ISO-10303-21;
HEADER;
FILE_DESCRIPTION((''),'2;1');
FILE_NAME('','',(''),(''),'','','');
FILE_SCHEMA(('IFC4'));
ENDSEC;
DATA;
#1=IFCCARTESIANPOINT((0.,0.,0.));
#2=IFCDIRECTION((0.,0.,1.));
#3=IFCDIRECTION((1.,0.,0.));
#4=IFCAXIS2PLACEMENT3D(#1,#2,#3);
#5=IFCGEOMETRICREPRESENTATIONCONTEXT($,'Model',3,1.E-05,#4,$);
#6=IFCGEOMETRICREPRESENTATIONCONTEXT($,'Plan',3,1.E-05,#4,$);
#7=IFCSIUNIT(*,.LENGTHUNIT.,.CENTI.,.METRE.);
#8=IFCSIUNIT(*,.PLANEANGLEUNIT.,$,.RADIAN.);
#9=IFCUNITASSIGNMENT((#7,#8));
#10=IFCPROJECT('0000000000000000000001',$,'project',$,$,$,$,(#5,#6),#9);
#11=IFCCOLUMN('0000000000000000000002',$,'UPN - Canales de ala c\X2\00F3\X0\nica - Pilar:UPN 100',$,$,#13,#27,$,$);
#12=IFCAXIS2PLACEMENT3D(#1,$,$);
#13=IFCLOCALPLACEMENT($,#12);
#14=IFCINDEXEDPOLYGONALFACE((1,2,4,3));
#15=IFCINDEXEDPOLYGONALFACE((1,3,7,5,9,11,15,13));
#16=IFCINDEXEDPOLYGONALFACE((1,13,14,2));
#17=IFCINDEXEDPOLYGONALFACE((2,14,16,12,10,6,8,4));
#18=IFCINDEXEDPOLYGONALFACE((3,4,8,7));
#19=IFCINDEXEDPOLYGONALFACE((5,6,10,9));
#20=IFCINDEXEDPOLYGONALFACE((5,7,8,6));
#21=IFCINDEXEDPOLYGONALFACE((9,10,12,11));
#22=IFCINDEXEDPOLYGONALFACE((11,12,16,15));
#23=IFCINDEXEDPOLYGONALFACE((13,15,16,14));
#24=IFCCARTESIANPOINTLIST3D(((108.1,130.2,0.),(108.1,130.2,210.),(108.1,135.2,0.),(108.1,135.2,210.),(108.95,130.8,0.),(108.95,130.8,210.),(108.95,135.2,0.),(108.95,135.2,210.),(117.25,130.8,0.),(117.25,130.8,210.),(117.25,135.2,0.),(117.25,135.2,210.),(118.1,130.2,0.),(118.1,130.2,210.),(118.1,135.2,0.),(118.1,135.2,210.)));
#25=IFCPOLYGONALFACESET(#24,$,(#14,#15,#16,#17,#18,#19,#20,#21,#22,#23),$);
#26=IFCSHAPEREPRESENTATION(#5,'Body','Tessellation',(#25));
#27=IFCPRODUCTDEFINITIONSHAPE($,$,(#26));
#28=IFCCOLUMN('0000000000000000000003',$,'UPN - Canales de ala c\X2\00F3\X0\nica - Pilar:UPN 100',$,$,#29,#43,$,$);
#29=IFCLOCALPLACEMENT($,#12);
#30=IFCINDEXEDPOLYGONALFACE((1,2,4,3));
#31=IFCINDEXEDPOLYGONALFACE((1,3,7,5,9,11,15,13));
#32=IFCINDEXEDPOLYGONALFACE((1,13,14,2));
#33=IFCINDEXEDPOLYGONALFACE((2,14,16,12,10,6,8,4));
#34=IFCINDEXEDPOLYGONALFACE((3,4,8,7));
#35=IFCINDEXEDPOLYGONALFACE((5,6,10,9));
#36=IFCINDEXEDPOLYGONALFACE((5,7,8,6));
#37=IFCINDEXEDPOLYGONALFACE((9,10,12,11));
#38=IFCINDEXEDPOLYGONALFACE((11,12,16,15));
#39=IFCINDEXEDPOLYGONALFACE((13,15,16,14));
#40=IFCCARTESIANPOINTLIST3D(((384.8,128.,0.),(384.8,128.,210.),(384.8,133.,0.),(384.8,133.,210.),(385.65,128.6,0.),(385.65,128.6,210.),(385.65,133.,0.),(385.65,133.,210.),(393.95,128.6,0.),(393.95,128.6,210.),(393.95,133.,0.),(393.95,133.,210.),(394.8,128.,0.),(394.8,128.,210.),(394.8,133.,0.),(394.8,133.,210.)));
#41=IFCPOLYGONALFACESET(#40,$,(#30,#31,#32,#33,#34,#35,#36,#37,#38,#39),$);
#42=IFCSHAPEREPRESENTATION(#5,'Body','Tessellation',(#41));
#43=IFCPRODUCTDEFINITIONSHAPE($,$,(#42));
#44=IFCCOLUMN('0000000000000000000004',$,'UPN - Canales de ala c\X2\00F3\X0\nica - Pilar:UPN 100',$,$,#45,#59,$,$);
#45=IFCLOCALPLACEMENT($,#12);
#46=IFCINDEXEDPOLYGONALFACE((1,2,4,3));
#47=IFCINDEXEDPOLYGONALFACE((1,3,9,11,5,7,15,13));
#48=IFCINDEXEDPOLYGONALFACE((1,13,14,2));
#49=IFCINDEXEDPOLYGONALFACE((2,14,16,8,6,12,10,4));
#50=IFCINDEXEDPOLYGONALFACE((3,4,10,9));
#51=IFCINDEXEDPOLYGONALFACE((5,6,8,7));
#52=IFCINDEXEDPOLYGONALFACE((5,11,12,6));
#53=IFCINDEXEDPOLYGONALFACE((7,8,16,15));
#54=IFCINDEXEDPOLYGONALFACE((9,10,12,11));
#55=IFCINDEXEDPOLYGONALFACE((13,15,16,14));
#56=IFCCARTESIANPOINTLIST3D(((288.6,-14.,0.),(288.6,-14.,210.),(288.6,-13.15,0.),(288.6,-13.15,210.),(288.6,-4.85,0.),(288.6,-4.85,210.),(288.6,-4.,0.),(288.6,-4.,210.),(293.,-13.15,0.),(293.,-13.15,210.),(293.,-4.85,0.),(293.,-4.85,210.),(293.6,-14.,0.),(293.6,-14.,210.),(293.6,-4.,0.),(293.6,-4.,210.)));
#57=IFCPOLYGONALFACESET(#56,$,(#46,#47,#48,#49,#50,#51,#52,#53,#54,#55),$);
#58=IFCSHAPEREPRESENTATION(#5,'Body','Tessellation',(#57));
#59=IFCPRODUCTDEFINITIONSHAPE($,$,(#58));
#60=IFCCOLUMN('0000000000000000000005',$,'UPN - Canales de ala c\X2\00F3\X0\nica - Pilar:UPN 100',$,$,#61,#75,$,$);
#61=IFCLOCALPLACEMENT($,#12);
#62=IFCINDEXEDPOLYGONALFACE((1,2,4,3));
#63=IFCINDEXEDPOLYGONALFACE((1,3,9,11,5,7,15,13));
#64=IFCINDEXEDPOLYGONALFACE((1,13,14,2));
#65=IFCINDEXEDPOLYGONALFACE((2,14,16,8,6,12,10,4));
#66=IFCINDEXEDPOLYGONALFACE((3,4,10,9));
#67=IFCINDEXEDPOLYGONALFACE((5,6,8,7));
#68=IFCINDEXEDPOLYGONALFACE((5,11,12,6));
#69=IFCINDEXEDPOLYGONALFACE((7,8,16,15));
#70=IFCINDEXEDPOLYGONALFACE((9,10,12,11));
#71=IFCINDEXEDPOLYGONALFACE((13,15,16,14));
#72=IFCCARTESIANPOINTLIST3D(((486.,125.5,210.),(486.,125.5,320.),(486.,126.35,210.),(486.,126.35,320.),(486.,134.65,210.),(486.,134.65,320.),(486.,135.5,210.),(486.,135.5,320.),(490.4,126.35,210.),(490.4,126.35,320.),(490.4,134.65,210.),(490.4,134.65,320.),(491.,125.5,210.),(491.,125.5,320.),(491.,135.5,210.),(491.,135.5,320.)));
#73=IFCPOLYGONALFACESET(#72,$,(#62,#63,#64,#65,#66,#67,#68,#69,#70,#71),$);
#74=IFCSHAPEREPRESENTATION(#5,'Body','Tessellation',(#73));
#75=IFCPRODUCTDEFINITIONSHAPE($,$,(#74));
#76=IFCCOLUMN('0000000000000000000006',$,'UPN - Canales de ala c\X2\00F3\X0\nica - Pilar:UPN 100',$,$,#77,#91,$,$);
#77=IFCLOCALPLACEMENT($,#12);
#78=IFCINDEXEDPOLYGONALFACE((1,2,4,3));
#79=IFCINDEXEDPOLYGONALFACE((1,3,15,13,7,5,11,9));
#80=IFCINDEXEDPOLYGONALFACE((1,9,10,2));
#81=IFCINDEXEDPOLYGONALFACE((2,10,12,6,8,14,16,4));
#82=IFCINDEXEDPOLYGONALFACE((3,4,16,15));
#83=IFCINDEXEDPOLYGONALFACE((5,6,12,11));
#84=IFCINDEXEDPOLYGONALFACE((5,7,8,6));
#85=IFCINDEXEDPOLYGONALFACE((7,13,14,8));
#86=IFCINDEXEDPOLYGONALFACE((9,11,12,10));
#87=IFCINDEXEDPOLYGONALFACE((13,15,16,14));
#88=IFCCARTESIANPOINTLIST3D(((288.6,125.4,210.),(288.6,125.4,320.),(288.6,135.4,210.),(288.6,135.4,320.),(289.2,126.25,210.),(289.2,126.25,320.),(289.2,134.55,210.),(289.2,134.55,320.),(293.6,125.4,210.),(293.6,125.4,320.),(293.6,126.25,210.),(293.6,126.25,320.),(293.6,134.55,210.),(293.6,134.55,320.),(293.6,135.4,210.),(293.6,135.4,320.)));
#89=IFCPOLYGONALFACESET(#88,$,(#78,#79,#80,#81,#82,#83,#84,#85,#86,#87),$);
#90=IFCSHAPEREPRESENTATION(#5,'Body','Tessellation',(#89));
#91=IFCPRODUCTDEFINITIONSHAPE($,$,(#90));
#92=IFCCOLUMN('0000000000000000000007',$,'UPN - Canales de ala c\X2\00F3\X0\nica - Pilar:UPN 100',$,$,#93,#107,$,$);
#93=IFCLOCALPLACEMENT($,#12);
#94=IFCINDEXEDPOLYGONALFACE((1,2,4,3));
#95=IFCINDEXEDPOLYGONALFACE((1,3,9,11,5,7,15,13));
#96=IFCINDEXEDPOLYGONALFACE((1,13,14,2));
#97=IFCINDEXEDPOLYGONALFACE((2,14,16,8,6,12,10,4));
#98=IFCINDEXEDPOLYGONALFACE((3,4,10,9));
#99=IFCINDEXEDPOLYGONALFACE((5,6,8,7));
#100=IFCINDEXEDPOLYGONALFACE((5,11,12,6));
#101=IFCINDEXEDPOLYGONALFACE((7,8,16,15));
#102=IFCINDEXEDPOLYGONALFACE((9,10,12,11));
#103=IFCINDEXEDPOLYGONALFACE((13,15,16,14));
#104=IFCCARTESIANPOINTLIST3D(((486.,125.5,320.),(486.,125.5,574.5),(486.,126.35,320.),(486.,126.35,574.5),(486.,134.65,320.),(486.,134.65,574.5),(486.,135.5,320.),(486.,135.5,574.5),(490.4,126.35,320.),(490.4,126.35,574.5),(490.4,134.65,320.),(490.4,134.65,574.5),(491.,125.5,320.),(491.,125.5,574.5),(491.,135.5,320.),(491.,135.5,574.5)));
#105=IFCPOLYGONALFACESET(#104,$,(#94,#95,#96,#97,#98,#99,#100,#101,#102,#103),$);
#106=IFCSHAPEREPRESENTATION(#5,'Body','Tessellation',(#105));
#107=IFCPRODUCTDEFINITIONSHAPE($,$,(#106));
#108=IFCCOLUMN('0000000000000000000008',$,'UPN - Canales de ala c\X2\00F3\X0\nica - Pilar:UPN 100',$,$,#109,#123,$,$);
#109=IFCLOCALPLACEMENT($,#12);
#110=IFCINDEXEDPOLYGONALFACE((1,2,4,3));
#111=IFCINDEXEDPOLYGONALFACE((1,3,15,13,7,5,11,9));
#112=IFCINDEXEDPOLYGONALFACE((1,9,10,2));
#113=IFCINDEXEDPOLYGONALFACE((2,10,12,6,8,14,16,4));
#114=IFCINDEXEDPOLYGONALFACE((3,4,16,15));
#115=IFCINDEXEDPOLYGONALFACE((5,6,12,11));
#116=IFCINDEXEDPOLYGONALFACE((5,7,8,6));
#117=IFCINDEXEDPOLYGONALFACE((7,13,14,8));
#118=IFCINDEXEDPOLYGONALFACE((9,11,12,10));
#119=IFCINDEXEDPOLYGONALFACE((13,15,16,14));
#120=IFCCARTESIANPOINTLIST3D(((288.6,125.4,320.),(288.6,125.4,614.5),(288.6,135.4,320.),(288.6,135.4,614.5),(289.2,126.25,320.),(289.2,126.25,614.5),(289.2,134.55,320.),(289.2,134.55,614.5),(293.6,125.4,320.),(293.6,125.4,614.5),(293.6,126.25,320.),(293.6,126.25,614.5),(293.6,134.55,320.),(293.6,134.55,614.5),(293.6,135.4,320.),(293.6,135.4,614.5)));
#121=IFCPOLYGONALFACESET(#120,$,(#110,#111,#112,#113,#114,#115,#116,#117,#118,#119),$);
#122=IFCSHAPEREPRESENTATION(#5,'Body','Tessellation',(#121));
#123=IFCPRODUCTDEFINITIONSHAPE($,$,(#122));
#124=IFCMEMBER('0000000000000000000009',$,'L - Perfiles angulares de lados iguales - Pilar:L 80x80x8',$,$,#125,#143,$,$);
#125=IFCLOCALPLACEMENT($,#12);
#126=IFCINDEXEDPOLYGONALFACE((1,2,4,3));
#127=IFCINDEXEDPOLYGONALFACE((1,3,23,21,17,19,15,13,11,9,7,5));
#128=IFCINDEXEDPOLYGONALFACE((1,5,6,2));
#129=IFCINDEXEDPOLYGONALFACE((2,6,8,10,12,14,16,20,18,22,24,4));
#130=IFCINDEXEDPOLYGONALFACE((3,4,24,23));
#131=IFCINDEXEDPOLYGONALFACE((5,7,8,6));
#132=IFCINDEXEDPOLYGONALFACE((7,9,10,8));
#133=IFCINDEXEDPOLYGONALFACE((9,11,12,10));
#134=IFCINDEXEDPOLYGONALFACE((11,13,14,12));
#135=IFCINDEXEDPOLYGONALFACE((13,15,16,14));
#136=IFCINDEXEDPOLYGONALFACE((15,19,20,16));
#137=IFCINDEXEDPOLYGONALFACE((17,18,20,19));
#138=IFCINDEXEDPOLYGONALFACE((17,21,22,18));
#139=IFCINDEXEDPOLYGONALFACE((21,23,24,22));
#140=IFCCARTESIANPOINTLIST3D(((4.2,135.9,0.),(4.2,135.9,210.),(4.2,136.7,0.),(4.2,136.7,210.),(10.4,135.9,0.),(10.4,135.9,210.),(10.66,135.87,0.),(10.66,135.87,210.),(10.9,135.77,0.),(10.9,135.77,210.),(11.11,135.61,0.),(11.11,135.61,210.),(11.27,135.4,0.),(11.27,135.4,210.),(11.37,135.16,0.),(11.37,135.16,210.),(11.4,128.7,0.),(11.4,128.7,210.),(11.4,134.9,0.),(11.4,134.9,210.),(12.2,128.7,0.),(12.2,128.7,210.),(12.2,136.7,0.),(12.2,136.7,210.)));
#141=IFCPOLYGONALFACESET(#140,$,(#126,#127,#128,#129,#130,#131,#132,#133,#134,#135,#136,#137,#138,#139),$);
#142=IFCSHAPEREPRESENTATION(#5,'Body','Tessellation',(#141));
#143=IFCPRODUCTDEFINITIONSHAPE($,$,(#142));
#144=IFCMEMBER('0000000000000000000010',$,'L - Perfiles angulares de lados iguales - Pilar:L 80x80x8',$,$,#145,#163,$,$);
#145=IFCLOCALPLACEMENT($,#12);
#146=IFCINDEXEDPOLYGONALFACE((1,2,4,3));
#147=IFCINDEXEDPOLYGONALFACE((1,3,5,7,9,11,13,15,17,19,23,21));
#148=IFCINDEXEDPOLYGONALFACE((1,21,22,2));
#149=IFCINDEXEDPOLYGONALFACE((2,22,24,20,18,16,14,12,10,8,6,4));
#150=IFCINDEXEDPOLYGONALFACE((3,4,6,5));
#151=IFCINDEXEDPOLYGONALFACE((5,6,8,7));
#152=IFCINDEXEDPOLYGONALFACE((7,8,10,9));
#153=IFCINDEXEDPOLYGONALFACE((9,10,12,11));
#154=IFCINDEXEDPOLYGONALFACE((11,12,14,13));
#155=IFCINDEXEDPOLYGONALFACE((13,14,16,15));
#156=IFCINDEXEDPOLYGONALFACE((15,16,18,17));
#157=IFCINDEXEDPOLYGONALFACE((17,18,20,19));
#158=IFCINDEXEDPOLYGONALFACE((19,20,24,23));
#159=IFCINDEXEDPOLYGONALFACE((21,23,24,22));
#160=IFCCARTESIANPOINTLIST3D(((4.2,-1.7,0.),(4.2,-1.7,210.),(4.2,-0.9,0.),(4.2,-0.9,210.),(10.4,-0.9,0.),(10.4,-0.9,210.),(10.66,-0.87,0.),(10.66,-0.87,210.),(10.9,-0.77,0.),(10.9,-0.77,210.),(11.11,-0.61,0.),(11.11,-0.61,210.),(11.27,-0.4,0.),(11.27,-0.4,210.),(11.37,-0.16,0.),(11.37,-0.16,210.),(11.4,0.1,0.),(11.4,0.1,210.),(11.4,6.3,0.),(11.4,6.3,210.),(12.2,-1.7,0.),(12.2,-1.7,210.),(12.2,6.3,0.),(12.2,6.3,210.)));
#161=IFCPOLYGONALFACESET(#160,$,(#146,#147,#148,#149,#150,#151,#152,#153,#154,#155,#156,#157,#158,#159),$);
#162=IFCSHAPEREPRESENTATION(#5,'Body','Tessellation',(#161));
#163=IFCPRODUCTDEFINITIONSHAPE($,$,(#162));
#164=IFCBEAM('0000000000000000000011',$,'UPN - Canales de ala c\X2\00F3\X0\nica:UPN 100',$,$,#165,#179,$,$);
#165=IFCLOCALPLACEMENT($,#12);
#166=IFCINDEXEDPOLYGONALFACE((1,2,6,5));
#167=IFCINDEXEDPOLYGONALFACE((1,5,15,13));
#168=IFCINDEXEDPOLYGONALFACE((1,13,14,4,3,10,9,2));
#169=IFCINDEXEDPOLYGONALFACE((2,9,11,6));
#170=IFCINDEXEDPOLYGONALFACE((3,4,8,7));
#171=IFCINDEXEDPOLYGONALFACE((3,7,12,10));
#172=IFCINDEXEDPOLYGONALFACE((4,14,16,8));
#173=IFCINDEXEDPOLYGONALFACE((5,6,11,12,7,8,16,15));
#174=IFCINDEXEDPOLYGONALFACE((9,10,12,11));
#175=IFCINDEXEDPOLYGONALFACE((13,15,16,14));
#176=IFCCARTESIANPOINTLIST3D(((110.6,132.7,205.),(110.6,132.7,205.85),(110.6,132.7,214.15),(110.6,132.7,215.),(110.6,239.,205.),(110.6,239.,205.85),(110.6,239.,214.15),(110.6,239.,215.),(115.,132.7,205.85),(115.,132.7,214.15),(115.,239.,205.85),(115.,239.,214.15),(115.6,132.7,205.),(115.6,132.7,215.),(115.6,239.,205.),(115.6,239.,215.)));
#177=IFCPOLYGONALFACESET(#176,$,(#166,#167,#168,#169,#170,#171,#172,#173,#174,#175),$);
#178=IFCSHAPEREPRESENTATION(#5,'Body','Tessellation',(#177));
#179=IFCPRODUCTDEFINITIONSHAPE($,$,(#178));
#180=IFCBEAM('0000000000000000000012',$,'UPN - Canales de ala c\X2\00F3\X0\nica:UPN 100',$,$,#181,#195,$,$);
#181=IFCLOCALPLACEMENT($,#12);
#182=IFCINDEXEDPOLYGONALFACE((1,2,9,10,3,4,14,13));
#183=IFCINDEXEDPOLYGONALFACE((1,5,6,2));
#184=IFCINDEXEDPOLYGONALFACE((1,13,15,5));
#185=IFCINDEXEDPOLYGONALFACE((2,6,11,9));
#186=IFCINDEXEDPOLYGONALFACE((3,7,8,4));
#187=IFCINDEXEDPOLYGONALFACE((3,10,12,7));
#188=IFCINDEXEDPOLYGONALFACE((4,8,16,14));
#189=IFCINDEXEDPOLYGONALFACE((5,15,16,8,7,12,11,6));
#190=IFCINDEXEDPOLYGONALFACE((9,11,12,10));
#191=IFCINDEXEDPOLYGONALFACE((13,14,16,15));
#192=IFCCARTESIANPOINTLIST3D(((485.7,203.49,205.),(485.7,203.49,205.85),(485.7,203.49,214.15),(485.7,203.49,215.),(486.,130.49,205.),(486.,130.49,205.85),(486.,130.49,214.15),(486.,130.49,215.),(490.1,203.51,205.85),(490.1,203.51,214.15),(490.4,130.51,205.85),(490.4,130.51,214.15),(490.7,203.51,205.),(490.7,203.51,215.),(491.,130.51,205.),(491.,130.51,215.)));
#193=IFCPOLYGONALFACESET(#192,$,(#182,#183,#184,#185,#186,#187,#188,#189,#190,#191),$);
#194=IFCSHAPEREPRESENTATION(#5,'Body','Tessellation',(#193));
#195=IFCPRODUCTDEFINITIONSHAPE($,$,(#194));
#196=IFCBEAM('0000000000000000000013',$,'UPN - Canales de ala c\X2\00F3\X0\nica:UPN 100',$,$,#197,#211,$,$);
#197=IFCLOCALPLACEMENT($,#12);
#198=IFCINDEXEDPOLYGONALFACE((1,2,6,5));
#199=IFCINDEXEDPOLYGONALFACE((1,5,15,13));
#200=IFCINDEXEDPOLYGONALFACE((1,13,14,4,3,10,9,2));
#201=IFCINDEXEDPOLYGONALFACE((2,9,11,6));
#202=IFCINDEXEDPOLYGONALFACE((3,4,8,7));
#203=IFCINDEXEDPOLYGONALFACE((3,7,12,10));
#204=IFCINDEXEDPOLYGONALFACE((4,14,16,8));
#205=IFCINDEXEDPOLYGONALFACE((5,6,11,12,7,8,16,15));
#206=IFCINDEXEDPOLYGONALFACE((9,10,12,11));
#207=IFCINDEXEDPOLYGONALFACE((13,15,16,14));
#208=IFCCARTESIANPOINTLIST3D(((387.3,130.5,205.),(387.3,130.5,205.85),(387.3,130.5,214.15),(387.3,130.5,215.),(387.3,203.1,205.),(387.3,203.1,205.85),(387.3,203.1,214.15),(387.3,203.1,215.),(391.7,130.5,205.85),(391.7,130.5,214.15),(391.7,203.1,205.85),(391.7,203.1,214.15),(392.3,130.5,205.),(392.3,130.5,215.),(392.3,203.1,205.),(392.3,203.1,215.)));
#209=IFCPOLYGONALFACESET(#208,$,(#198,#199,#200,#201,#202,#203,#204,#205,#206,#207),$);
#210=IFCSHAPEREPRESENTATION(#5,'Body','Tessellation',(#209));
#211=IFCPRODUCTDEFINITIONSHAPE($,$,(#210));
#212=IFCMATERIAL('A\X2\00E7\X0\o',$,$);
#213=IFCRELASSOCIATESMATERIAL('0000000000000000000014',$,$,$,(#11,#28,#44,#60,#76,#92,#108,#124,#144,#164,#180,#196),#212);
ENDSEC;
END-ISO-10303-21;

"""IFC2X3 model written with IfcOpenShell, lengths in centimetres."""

from ifc_helpers import new_model, si_unit, frame, frame_2d, origin_with_axes, origin_2d_with_axis, place, context, project, l_section, u_section, extrude, material, element, save


model = new_model("IFC2X3")

# Units and contexts
model_context = context("Model", 3, precision=1e-05, world=origin_with_axes())
plan_context = context("Plan", 3, precision=1e-05, world=origin_with_axes())
ifc_project = project(units=[si_unit("LENGTHUNIT", "METRE", prefix="CENTI"), si_unit("PLANEANGLEUNIT", "RADIAN")], contexts=[model_context, plan_context])

# Columns
ifc_material = material(Name="Aço")
for number, where, z_axis, x_axis, name in (
    (1, (113.1, 132.7, 0.0), (0.0, 0.0, 1.0), (0.0, 1.0, 0.0), "UPN - Canales de ala cónica - Pilar:UPN 100"),
    (2, (389.8, 130.5, 0.0), (0.0, 0.0, 1.0), (0.0, 1.0, 0.0), "UPN - Canales de ala cónica - Pilar:UPN 100"),
    (3, (291.1, -9.0, 0.0), (0.0, 0.0, 1.0), (-1.0, 0.0, 0.0), "UPN - Canales de ala cónica - Pilar:UPN 100"),
):
    element("IfcColumn", number, at=place(None, frame(where, z_axis=z_axis, x_axis=x_axis)), material=ifc_material, Name=name, context=model_context, shape_type="SweptSolid", body=[
        extrude(u_section(Depth=10.0, FlangeWidth=5.0, WebThickness=0.6, FlangeThickness=0.85, FilletRadius=0.0, EdgeRadius=0.0, FlangeSlope=0.0, CentreOfGravityInX=0.0, at=origin_2d_with_axis()), origin_with_axes(), (0.0, 0.0, 1.0), 210.0),
    ])
for number, where, z_axis, x_axis, name in (
    (4, (488.5, 130.5, 210.0), (0.0, 0.0, 1.0), (-1.0, 0.0, 0.0), "UPN - Canales de ala cónica - Pilar:UPN 100"),
    (5, (291.1, 130.4, 210.0), (0.0, 0.0, 1.0), (1.0, 0.0, 0.0), "UPN - Canales de ala cónica - Pilar:UPN 100"),
):
    element("IfcColumn", number, at=place(None, frame(where, z_axis=z_axis, x_axis=x_axis)), material=ifc_material, Name=name, context=model_context, shape_type="SweptSolid", body=[
        extrude(u_section(Depth=10.0, FlangeWidth=5.0, WebThickness=0.6, FlangeThickness=0.85, FilletRadius=0.0, EdgeRadius=0.0, FlangeSlope=0.0, CentreOfGravityInX=0.0, at=origin_2d_with_axis()), origin_with_axes(), (0.0, 0.0, 1.0), 110.0),
    ])
column_1_placement = place(None, frame((488.5, 130.5, 320.0), z_axis=(0.0, 0.0, 1.0), x_axis=(-1.0, 0.0, 0.0)))
element("IfcColumn", 6, at=column_1_placement, material=ifc_material, Name="UPN - Canales de ala cónica - Pilar:UPN 100", context=model_context, shape_type="SweptSolid", body=[
    extrude(u_section(Depth=10.0, FlangeWidth=5.0, WebThickness=0.6, FlangeThickness=0.85, FilletRadius=0.0, EdgeRadius=0.0, FlangeSlope=0.0, CentreOfGravityInX=0.0, at=origin_2d_with_axis()), origin_with_axes(), (0.0, 0.0, 1.0), 254.5),
])
column_2_placement = place(None, frame((291.1, 130.4, 320.0), z_axis=(0.0, 0.0, 1.0), x_axis=(1.0, 0.0, 0.0)))
element("IfcColumn", 7, at=column_2_placement, material=ifc_material, Name="UPN - Canales de ala cónica - Pilar:UPN 100", context=model_context, shape_type="SweptSolid", body=[
    extrude(u_section(Depth=10.0, FlangeWidth=5.0, WebThickness=0.6, FlangeThickness=0.85, FilletRadius=0.0, EdgeRadius=0.0, FlangeSlope=0.0, CentreOfGravityInX=0.0, at=origin_2d_with_axis()), origin_with_axes(), (0.0, 0.0, 1.0), 294.5),
])

# Members
member_1_placement = place(None, frame((8.2, 132.7, 0.0), z_axis=(0.0, 0.0, 1.0), x_axis=(-1.0, 0.0, 0.0)))
element("IfcMember", 8, at=member_1_placement, material=ifc_material, Name="L - Perfiles angulares de lados iguales - Pilar:L 80x80x8", context=model_context, shape_type="SweptSolid", body=[
    extrude(l_section(Depth=8.0, Width=8.0, Thickness=0.8, FilletRadius=1.0, EdgeRadius=0.0, LegSlope=0.0, CentreOfGravityInX=0.0, CentreOfGravityInY=0.0, at=origin_2d_with_axis()), origin_with_axes(), (0.0, 0.0, 1.0), 210.0),
])
member_2_placement = place(None, frame((8.2, 2.3, 0.0), z_axis=(0.0, 0.0, 1.0), x_axis=(0.0, 1.0, 0.0)))
element("IfcMember", 9, at=member_2_placement, material=ifc_material, Name="L - Perfiles angulares de lados iguales - Pilar:L 80x80x8", context=model_context, shape_type="SweptSolid", body=[
    extrude(l_section(Depth=8.0, Width=8.0, Thickness=0.8, FilletRadius=1.0, EdgeRadius=0.0, LegSlope=0.0, CentreOfGravityInX=0.0, CentreOfGravityInY=0.0, at=frame_2d((0.0, 0.0), x_axis=(1.0, 0.0))), origin_with_axes(), (0.0, 0.0, 1.0), 210.0),
])

# Beams
beam_1_placement = place(None, frame((113.1, 132.7, 210.0), z_axis=(0.0, 1.0, 0.0), x_axis=(-1.0, 0.0, 0.0)))
element("IfcBeam", 10, at=beam_1_placement, material=ifc_material, Name="UPN - Canales de ala cónica:UPN 100", context=model_context, shape_type="SweptSolid", body=[
    extrude(u_section(Depth=10.0, FlangeWidth=5.0, WebThickness=0.6, FlangeThickness=0.85, FilletRadius=0.0, EdgeRadius=0.0, FlangeSlope=0.0, CentreOfGravityInX=0.0, at=origin_2d_with_axis()), origin_with_axes(), (0.0, 0.0, 1.0), 106.3),
])
beam_2_placement = place(None, frame((488.5, 130.5, 210.0), z_axis=(-0.004109, 0.999992, 0.0), x_axis=(-0.999992, -0.004109, 0.0)))
element("IfcBeam", 11, at=beam_2_placement, material=ifc_material, Name="UPN - Canales de ala cónica:UPN 100", context=model_context, shape_type="SweptSolid", body=[
    extrude(u_section(Depth=10.0, FlangeWidth=5.0, WebThickness=0.6, FlangeThickness=0.85, FilletRadius=0.0, EdgeRadius=0.0, FlangeSlope=0.0, CentreOfGravityInX=0.0, at=frame_2d((0.0, 0.0), x_axis=(1.0, 0.0))), origin_with_axes(), (0.0, 0.0, 1.0), 73.0),
])
beam_3_placement = place(None, frame((389.8, 130.5, 210.0), z_axis=(0.0, 1.0, 0.0), x_axis=(-1.0, 0.0, 0.0)))
element("IfcBeam", 12, at=beam_3_placement, material=ifc_material, Name="UPN - Canales de ala cónica:UPN 100", context=model_context, shape_type="SweptSolid", body=[
    extrude(u_section(Depth=10.0, FlangeWidth=5.0, WebThickness=0.6, FlangeThickness=0.85, FilletRadius=0.0, EdgeRadius=0.0, FlangeSlope=0.0, CentreOfGravityInX=0.0, at=origin_2d_with_axis()), origin_with_axes(), (0.0, 0.0, 1.0), 72.6),
])

save(model, "model.ifc")
